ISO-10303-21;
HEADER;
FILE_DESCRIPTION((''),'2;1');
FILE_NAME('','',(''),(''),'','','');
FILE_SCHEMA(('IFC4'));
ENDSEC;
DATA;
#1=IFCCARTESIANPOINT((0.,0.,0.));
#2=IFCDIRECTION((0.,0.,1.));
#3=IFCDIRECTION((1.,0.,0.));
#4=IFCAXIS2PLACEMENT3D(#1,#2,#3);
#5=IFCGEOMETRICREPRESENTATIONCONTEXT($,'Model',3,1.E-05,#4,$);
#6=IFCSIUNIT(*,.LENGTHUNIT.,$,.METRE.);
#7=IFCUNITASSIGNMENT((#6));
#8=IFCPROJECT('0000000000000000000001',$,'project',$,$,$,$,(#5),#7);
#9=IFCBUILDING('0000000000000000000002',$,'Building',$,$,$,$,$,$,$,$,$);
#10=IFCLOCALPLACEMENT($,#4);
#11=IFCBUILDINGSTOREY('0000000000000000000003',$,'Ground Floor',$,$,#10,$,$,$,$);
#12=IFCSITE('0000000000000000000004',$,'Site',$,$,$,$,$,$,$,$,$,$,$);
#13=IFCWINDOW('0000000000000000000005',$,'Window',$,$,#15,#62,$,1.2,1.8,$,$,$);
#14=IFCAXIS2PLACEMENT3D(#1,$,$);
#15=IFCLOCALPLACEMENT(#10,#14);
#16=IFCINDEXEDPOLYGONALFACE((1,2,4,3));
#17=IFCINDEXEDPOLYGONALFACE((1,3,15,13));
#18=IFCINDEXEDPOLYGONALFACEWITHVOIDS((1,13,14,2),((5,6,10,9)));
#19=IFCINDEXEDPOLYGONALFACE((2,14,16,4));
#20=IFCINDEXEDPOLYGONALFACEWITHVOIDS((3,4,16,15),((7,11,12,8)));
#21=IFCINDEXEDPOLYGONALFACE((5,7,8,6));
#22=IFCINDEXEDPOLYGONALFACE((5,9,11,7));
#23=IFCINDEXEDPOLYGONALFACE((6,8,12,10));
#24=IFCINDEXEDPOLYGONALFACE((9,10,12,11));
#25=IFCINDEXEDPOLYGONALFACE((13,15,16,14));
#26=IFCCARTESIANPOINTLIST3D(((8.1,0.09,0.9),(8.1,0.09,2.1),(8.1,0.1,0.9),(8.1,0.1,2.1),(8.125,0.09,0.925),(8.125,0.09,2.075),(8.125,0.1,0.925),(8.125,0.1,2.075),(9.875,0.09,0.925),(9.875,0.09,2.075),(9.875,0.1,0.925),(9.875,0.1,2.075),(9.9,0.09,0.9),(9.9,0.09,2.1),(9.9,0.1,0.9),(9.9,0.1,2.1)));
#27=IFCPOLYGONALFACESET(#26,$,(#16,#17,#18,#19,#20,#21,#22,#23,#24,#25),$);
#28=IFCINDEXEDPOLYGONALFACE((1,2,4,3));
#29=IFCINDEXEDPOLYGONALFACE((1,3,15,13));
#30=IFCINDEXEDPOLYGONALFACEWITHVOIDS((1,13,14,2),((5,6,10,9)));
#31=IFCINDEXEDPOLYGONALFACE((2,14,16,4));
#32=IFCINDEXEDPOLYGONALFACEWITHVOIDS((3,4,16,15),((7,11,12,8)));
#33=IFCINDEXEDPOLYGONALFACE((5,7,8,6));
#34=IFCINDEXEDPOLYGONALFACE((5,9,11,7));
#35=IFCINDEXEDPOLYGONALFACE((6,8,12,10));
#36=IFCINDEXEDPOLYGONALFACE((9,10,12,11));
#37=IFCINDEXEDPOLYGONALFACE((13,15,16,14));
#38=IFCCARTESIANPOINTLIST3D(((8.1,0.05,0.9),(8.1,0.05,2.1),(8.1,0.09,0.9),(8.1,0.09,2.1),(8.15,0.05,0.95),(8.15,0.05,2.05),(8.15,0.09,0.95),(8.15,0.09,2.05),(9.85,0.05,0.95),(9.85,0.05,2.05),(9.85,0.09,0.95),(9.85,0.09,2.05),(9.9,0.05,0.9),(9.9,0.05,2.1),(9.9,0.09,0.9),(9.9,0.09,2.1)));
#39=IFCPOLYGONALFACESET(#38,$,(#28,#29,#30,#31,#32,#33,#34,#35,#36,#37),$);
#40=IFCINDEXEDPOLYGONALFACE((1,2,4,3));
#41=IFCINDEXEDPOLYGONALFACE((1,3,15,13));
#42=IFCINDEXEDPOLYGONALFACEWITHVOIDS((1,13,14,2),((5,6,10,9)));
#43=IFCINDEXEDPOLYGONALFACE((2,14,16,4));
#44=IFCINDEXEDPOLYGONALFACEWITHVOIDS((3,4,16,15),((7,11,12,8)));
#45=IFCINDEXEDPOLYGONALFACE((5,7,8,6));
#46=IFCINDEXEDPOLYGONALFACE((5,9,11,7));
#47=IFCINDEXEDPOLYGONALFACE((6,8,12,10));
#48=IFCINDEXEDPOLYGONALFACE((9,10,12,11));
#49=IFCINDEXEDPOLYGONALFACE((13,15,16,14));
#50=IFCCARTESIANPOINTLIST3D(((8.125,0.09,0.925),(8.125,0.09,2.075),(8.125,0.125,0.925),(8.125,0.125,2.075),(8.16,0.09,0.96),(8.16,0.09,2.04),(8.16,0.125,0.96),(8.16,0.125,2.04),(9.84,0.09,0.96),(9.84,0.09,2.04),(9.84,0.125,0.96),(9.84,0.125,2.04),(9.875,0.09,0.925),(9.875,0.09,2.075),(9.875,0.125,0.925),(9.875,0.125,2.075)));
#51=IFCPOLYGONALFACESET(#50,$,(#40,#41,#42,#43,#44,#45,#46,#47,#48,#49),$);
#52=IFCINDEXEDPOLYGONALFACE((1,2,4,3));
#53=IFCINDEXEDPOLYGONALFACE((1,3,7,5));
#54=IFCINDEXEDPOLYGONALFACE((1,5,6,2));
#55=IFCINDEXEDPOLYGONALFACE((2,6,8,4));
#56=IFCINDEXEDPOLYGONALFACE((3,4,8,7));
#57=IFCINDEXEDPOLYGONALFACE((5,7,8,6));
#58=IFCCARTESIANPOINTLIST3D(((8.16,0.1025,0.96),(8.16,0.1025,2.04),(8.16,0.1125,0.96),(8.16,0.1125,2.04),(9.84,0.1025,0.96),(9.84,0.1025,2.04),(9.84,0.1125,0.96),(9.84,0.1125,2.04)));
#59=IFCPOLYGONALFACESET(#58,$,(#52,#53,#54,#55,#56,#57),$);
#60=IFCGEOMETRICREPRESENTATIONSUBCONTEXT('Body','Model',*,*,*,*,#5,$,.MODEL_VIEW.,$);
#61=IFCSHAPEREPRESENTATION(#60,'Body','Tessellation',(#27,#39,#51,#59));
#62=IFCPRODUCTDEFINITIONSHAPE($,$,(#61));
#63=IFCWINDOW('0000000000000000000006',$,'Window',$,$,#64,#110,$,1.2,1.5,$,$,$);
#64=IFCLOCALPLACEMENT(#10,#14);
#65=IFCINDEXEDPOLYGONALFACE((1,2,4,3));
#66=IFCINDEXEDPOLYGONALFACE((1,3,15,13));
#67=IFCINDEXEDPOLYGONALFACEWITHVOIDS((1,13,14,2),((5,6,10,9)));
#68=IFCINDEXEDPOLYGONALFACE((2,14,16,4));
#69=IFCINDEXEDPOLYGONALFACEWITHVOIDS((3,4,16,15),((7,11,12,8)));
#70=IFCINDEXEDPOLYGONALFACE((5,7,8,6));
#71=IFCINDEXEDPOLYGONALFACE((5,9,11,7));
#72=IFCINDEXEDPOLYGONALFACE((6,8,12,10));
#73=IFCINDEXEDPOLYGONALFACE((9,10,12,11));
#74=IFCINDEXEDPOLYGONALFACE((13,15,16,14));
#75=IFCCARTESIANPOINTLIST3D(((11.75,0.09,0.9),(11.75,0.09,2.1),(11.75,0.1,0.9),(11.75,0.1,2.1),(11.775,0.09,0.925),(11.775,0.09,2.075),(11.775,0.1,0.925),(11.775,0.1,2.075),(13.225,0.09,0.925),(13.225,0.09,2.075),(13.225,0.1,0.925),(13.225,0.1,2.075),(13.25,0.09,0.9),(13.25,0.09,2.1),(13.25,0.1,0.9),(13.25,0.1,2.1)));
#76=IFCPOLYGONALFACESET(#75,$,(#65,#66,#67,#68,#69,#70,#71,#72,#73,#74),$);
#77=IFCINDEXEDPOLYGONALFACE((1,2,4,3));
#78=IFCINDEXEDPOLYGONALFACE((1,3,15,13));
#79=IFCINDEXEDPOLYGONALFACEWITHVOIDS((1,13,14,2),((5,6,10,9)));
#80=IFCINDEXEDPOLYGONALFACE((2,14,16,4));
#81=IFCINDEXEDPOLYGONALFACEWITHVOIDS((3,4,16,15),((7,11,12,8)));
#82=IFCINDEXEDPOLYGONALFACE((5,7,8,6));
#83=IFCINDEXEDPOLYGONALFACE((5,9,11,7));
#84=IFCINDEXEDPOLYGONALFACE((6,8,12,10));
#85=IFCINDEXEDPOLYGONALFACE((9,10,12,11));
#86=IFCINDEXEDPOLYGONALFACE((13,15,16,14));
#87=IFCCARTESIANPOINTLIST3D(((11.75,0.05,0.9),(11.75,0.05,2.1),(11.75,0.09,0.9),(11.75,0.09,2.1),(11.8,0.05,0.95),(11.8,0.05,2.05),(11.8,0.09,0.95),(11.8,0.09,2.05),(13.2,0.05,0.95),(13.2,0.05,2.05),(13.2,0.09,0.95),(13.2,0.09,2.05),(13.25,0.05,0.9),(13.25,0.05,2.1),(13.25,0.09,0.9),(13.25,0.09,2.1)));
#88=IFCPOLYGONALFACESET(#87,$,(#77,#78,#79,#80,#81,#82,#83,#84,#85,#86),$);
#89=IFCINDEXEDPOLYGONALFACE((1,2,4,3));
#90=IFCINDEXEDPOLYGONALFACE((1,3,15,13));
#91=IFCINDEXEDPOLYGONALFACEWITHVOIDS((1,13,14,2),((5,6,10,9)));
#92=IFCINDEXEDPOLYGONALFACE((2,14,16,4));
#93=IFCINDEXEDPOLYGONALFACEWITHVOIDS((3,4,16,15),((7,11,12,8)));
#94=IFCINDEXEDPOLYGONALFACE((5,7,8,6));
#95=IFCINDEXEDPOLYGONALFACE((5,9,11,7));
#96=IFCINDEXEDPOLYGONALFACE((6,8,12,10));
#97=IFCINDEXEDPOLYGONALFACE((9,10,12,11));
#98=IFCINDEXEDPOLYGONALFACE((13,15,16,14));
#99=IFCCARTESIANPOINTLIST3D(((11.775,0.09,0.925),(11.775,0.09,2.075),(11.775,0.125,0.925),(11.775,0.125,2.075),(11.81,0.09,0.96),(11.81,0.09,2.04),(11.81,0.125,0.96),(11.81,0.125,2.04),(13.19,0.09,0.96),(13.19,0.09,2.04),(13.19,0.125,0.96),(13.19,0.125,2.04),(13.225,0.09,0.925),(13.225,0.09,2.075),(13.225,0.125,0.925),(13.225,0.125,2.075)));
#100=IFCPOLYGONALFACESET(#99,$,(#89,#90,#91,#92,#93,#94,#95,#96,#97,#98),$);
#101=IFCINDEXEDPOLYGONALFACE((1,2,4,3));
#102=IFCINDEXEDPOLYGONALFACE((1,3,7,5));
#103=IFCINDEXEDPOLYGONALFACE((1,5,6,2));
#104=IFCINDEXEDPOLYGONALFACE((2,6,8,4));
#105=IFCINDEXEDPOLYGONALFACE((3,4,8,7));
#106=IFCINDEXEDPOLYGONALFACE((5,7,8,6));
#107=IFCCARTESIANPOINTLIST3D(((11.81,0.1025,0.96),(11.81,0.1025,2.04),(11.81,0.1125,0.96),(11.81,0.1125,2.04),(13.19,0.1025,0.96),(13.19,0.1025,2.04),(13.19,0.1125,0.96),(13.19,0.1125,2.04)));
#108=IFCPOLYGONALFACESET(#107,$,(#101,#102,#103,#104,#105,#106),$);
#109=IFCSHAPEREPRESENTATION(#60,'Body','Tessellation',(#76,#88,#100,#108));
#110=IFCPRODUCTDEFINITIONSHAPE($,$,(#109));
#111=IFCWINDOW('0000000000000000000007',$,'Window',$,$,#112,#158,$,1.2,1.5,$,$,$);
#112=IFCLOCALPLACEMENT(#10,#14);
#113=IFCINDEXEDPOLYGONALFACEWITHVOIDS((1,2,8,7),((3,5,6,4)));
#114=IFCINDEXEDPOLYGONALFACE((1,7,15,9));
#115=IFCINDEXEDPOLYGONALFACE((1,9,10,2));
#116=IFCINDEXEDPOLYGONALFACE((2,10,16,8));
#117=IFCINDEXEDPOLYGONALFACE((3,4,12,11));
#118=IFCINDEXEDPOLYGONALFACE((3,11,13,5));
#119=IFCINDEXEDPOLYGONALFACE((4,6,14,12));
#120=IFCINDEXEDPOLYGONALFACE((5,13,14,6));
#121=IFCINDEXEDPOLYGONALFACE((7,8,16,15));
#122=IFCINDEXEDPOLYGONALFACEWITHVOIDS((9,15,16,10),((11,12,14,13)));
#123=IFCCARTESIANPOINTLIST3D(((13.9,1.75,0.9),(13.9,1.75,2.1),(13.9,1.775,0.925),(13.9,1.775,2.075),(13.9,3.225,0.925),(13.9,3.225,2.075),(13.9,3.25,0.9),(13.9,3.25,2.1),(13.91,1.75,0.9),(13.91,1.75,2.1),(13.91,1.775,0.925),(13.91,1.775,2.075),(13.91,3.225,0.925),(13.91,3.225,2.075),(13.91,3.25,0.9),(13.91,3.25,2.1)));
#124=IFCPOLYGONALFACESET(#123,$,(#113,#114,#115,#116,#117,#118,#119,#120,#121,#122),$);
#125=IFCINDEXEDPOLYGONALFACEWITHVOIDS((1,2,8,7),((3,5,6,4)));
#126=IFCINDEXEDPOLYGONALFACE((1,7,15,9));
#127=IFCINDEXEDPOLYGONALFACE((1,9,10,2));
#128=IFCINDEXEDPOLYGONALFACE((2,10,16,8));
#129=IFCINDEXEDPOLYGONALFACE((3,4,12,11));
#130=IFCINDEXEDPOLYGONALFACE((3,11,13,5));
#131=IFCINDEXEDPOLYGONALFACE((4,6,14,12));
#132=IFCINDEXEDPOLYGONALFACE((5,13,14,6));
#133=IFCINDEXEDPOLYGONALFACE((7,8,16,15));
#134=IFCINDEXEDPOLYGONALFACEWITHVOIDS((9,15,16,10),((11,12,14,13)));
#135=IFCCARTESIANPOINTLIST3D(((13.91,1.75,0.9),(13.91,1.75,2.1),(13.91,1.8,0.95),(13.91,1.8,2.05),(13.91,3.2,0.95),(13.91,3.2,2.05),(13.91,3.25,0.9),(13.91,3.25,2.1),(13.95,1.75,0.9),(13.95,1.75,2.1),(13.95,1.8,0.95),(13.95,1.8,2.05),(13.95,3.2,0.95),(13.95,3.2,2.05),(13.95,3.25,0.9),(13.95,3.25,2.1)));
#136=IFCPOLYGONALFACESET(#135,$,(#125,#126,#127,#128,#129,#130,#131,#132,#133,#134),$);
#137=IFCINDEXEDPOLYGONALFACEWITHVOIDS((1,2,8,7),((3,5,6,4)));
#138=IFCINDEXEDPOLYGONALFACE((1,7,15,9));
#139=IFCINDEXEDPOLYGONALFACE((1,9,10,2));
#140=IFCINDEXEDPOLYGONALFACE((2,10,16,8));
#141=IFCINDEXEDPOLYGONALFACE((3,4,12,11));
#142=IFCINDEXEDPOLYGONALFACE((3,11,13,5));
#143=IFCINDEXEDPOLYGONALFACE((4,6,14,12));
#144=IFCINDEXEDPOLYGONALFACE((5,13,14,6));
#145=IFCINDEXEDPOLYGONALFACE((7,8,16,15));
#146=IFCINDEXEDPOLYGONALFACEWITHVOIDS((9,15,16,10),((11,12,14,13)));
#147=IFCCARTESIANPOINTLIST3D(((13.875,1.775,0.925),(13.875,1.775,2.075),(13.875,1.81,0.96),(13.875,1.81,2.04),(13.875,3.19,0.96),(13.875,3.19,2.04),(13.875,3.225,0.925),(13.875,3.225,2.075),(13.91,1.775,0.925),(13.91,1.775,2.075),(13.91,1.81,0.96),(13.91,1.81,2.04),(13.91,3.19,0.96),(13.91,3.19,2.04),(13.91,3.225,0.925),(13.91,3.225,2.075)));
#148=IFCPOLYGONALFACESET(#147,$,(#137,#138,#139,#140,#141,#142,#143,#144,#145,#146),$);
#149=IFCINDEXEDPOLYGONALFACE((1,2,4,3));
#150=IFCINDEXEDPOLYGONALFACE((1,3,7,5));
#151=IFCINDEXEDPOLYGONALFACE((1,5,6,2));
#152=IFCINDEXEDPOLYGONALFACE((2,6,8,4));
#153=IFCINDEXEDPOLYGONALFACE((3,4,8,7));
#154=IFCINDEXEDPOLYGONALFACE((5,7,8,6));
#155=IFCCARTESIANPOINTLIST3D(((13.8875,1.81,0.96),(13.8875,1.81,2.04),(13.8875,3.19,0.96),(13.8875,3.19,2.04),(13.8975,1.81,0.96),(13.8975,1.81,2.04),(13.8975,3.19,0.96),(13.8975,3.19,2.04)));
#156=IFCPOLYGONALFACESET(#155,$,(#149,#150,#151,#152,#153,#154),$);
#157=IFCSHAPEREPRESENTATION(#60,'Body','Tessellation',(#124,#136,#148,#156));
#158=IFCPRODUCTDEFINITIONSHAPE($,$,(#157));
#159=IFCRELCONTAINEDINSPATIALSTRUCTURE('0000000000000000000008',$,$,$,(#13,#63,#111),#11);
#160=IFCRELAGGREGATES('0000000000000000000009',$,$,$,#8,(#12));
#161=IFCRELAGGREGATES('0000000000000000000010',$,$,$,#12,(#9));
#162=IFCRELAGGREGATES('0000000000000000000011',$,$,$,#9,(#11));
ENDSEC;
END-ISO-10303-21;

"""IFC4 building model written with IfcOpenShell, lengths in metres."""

from ifc_helpers import new_model, si_unit, frame, origin_with_axes, place, context, subcontext, project, spatial, line, indexed_curve, outline, extrude, element, save


model = new_model("IFC4")

# Units and contexts
model_context = context("Model", 3, precision=1e-05, world=origin_with_axes())
body_context = subcontext(model_context, "Body", "Model", "MODEL_VIEW")
ifc_project = project(units=[si_unit("LENGTHUNIT", "METRE")], contexts=[model_context])

# Site, building, storey
site = spatial("IfcSite", under=ifc_project, Name="Site")
building = spatial("IfcBuilding", under=site, Name="Building")
storey_placement = place(None, origin_with_axes())
storey = spatial("IfcBuildingStorey", under=building, at=storey_placement, Name="Ground Floor")

# Windows
window_placement = place(storey_placement, frame((8.1, 0.0, 0.9), z_axis=(0.0, 0.0, 1.0), x_axis=(1.0, 0.0, 0.0)))
element("IfcWindow", 1, at=window_placement, inside=storey, Name="Window", OverallHeight=1.2, OverallWidth=1.8, context=body_context, shape_type="SweptSolid", body=[
    extrude(outline(indexed_curve([(0.0, 0.0), (1.8, 0.0), (1.8, 1.2), (0.0, 1.2)], segments=[line(1, 2, 3, 4, 1)]), holes=[indexed_curve([(0.025, 0.025), (1.775, 0.025), (1.775, 1.175), (0.025, 1.175)], segments=[line(1, 2, 3, 4, 1)])]), frame((0.0, 0.09, 0.0), z_axis=(0.0, -1.0, 0.0), x_axis=(1.0, 0.0, 0.0)), (0.0, 0.0, -1.0), 0.01),
    extrude(outline(indexed_curve([(0.0, 0.0), (1.8, 0.0), (1.8, 1.2), (0.0, 1.2)], segments=[line(1, 2, 3, 4, 1)]), holes=[indexed_curve([(0.05, 0.05), (1.75, 0.05), (1.75, 1.15), (0.05, 1.15)], segments=[line(1, 2, 3, 4, 1)])]), frame((0.0, 0.05, 0.0), z_axis=(0.0, -1.0, 0.0), x_axis=(1.0, 0.0, 0.0)), (0.0, 0.0, -1.0), 0.04),
    extrude(outline(indexed_curve([(0.0, 0.0), (1.75, 0.0), (1.75, 1.15), (0.0, 1.15)], segments=[line(1, 2, 3, 4, 1)]), holes=[indexed_curve([(0.035, 0.035), (1.715, 0.035), (1.715, 1.115), (0.035, 1.115)], segments=[line(1, 2, 3, 4, 1)])]), frame((0.025, 0.09, 0.025), z_axis=(0.0, -1.0, 0.0), x_axis=(1.0, 0.0, 0.0)), (0.0, 0.0, -1.0), 0.035),
    extrude(outline(indexed_curve([(0.035, 0.035), (1.715, 0.035), (1.715, 1.115), (0.035, 1.115)], segments=[line(1, 2, 3, 4, 1)])), frame((0.025, 0.1025, 0.025), z_axis=(0.0, -1.0, 0.0), x_axis=(1.0, 0.0, 0.0)), (0.0, 0.0, -1.0), 0.01),
])
for number, where, z_axis, x_axis, name in (
    (2, (11.75, 0.0, 0.9), (0.0, 0.0, 1.0), (1.0, 0.0, 0.0), "Window"),
    (3, (14.0, 1.75, 0.9), (0.0, 0.0, 1.0), (0.0, 1.0, 0.0), "Window"),
):
    element("IfcWindow", number, at=place(storey_placement, frame(where, z_axis=z_axis, x_axis=x_axis)), inside=storey, Name=name, OverallHeight=1.2, OverallWidth=1.5, context=body_context, shape_type="SweptSolid", body=[
        extrude(outline(indexed_curve([(0.0, 0.0), (1.5, 0.0), (1.5, 1.2), (0.0, 1.2)], segments=[line(1, 2, 3, 4, 1)]), holes=[indexed_curve([(0.025, 0.025), (1.475, 0.025), (1.475, 1.175), (0.025, 1.175)], segments=[line(1, 2, 3, 4, 1)])]), frame((0.0, 0.09, 0.0), z_axis=(0.0, -1.0, 0.0), x_axis=(1.0, 0.0, 0.0)), (0.0, 0.0, -1.0), 0.01),
        extrude(outline(indexed_curve([(0.0, 0.0), (1.5, 0.0), (1.5, 1.2), (0.0, 1.2)], segments=[line(1, 2, 3, 4, 1)]), holes=[indexed_curve([(0.05, 0.05), (1.45, 0.05), (1.45, 1.15), (0.05, 1.15)], segments=[line(1, 2, 3, 4, 1)])]), frame((0.0, 0.05, 0.0), z_axis=(0.0, -1.0, 0.0), x_axis=(1.0, 0.0, 0.0)), (0.0, 0.0, -1.0), 0.04),
        extrude(outline(indexed_curve([(0.0, 0.0), (1.45, 0.0), (1.45, 1.15), (0.0, 1.15)], segments=[line(1, 2, 3, 4, 1)]), holes=[indexed_curve([(0.035, 0.035), (1.415, 0.035), (1.415, 1.115), (0.035, 1.115)], segments=[line(1, 2, 3, 4, 1)])]), frame((0.025, 0.09, 0.025), z_axis=(0.0, -1.0, 0.0), x_axis=(1.0, 0.0, 0.0)), (0.0, 0.0, -1.0), 0.035),
        extrude(outline(indexed_curve([(0.035, 0.035), (1.415, 0.035), (1.415, 1.115), (0.035, 1.115)], segments=[line(1, 2, 3, 4, 1)])), frame((0.025, 0.1025, 0.025), z_axis=(0.0, -1.0, 0.0), x_axis=(1.0, 0.0, 0.0)), (0.0, 0.0, -1.0), 0.01),
    ])

save(model, "model.ifc")
